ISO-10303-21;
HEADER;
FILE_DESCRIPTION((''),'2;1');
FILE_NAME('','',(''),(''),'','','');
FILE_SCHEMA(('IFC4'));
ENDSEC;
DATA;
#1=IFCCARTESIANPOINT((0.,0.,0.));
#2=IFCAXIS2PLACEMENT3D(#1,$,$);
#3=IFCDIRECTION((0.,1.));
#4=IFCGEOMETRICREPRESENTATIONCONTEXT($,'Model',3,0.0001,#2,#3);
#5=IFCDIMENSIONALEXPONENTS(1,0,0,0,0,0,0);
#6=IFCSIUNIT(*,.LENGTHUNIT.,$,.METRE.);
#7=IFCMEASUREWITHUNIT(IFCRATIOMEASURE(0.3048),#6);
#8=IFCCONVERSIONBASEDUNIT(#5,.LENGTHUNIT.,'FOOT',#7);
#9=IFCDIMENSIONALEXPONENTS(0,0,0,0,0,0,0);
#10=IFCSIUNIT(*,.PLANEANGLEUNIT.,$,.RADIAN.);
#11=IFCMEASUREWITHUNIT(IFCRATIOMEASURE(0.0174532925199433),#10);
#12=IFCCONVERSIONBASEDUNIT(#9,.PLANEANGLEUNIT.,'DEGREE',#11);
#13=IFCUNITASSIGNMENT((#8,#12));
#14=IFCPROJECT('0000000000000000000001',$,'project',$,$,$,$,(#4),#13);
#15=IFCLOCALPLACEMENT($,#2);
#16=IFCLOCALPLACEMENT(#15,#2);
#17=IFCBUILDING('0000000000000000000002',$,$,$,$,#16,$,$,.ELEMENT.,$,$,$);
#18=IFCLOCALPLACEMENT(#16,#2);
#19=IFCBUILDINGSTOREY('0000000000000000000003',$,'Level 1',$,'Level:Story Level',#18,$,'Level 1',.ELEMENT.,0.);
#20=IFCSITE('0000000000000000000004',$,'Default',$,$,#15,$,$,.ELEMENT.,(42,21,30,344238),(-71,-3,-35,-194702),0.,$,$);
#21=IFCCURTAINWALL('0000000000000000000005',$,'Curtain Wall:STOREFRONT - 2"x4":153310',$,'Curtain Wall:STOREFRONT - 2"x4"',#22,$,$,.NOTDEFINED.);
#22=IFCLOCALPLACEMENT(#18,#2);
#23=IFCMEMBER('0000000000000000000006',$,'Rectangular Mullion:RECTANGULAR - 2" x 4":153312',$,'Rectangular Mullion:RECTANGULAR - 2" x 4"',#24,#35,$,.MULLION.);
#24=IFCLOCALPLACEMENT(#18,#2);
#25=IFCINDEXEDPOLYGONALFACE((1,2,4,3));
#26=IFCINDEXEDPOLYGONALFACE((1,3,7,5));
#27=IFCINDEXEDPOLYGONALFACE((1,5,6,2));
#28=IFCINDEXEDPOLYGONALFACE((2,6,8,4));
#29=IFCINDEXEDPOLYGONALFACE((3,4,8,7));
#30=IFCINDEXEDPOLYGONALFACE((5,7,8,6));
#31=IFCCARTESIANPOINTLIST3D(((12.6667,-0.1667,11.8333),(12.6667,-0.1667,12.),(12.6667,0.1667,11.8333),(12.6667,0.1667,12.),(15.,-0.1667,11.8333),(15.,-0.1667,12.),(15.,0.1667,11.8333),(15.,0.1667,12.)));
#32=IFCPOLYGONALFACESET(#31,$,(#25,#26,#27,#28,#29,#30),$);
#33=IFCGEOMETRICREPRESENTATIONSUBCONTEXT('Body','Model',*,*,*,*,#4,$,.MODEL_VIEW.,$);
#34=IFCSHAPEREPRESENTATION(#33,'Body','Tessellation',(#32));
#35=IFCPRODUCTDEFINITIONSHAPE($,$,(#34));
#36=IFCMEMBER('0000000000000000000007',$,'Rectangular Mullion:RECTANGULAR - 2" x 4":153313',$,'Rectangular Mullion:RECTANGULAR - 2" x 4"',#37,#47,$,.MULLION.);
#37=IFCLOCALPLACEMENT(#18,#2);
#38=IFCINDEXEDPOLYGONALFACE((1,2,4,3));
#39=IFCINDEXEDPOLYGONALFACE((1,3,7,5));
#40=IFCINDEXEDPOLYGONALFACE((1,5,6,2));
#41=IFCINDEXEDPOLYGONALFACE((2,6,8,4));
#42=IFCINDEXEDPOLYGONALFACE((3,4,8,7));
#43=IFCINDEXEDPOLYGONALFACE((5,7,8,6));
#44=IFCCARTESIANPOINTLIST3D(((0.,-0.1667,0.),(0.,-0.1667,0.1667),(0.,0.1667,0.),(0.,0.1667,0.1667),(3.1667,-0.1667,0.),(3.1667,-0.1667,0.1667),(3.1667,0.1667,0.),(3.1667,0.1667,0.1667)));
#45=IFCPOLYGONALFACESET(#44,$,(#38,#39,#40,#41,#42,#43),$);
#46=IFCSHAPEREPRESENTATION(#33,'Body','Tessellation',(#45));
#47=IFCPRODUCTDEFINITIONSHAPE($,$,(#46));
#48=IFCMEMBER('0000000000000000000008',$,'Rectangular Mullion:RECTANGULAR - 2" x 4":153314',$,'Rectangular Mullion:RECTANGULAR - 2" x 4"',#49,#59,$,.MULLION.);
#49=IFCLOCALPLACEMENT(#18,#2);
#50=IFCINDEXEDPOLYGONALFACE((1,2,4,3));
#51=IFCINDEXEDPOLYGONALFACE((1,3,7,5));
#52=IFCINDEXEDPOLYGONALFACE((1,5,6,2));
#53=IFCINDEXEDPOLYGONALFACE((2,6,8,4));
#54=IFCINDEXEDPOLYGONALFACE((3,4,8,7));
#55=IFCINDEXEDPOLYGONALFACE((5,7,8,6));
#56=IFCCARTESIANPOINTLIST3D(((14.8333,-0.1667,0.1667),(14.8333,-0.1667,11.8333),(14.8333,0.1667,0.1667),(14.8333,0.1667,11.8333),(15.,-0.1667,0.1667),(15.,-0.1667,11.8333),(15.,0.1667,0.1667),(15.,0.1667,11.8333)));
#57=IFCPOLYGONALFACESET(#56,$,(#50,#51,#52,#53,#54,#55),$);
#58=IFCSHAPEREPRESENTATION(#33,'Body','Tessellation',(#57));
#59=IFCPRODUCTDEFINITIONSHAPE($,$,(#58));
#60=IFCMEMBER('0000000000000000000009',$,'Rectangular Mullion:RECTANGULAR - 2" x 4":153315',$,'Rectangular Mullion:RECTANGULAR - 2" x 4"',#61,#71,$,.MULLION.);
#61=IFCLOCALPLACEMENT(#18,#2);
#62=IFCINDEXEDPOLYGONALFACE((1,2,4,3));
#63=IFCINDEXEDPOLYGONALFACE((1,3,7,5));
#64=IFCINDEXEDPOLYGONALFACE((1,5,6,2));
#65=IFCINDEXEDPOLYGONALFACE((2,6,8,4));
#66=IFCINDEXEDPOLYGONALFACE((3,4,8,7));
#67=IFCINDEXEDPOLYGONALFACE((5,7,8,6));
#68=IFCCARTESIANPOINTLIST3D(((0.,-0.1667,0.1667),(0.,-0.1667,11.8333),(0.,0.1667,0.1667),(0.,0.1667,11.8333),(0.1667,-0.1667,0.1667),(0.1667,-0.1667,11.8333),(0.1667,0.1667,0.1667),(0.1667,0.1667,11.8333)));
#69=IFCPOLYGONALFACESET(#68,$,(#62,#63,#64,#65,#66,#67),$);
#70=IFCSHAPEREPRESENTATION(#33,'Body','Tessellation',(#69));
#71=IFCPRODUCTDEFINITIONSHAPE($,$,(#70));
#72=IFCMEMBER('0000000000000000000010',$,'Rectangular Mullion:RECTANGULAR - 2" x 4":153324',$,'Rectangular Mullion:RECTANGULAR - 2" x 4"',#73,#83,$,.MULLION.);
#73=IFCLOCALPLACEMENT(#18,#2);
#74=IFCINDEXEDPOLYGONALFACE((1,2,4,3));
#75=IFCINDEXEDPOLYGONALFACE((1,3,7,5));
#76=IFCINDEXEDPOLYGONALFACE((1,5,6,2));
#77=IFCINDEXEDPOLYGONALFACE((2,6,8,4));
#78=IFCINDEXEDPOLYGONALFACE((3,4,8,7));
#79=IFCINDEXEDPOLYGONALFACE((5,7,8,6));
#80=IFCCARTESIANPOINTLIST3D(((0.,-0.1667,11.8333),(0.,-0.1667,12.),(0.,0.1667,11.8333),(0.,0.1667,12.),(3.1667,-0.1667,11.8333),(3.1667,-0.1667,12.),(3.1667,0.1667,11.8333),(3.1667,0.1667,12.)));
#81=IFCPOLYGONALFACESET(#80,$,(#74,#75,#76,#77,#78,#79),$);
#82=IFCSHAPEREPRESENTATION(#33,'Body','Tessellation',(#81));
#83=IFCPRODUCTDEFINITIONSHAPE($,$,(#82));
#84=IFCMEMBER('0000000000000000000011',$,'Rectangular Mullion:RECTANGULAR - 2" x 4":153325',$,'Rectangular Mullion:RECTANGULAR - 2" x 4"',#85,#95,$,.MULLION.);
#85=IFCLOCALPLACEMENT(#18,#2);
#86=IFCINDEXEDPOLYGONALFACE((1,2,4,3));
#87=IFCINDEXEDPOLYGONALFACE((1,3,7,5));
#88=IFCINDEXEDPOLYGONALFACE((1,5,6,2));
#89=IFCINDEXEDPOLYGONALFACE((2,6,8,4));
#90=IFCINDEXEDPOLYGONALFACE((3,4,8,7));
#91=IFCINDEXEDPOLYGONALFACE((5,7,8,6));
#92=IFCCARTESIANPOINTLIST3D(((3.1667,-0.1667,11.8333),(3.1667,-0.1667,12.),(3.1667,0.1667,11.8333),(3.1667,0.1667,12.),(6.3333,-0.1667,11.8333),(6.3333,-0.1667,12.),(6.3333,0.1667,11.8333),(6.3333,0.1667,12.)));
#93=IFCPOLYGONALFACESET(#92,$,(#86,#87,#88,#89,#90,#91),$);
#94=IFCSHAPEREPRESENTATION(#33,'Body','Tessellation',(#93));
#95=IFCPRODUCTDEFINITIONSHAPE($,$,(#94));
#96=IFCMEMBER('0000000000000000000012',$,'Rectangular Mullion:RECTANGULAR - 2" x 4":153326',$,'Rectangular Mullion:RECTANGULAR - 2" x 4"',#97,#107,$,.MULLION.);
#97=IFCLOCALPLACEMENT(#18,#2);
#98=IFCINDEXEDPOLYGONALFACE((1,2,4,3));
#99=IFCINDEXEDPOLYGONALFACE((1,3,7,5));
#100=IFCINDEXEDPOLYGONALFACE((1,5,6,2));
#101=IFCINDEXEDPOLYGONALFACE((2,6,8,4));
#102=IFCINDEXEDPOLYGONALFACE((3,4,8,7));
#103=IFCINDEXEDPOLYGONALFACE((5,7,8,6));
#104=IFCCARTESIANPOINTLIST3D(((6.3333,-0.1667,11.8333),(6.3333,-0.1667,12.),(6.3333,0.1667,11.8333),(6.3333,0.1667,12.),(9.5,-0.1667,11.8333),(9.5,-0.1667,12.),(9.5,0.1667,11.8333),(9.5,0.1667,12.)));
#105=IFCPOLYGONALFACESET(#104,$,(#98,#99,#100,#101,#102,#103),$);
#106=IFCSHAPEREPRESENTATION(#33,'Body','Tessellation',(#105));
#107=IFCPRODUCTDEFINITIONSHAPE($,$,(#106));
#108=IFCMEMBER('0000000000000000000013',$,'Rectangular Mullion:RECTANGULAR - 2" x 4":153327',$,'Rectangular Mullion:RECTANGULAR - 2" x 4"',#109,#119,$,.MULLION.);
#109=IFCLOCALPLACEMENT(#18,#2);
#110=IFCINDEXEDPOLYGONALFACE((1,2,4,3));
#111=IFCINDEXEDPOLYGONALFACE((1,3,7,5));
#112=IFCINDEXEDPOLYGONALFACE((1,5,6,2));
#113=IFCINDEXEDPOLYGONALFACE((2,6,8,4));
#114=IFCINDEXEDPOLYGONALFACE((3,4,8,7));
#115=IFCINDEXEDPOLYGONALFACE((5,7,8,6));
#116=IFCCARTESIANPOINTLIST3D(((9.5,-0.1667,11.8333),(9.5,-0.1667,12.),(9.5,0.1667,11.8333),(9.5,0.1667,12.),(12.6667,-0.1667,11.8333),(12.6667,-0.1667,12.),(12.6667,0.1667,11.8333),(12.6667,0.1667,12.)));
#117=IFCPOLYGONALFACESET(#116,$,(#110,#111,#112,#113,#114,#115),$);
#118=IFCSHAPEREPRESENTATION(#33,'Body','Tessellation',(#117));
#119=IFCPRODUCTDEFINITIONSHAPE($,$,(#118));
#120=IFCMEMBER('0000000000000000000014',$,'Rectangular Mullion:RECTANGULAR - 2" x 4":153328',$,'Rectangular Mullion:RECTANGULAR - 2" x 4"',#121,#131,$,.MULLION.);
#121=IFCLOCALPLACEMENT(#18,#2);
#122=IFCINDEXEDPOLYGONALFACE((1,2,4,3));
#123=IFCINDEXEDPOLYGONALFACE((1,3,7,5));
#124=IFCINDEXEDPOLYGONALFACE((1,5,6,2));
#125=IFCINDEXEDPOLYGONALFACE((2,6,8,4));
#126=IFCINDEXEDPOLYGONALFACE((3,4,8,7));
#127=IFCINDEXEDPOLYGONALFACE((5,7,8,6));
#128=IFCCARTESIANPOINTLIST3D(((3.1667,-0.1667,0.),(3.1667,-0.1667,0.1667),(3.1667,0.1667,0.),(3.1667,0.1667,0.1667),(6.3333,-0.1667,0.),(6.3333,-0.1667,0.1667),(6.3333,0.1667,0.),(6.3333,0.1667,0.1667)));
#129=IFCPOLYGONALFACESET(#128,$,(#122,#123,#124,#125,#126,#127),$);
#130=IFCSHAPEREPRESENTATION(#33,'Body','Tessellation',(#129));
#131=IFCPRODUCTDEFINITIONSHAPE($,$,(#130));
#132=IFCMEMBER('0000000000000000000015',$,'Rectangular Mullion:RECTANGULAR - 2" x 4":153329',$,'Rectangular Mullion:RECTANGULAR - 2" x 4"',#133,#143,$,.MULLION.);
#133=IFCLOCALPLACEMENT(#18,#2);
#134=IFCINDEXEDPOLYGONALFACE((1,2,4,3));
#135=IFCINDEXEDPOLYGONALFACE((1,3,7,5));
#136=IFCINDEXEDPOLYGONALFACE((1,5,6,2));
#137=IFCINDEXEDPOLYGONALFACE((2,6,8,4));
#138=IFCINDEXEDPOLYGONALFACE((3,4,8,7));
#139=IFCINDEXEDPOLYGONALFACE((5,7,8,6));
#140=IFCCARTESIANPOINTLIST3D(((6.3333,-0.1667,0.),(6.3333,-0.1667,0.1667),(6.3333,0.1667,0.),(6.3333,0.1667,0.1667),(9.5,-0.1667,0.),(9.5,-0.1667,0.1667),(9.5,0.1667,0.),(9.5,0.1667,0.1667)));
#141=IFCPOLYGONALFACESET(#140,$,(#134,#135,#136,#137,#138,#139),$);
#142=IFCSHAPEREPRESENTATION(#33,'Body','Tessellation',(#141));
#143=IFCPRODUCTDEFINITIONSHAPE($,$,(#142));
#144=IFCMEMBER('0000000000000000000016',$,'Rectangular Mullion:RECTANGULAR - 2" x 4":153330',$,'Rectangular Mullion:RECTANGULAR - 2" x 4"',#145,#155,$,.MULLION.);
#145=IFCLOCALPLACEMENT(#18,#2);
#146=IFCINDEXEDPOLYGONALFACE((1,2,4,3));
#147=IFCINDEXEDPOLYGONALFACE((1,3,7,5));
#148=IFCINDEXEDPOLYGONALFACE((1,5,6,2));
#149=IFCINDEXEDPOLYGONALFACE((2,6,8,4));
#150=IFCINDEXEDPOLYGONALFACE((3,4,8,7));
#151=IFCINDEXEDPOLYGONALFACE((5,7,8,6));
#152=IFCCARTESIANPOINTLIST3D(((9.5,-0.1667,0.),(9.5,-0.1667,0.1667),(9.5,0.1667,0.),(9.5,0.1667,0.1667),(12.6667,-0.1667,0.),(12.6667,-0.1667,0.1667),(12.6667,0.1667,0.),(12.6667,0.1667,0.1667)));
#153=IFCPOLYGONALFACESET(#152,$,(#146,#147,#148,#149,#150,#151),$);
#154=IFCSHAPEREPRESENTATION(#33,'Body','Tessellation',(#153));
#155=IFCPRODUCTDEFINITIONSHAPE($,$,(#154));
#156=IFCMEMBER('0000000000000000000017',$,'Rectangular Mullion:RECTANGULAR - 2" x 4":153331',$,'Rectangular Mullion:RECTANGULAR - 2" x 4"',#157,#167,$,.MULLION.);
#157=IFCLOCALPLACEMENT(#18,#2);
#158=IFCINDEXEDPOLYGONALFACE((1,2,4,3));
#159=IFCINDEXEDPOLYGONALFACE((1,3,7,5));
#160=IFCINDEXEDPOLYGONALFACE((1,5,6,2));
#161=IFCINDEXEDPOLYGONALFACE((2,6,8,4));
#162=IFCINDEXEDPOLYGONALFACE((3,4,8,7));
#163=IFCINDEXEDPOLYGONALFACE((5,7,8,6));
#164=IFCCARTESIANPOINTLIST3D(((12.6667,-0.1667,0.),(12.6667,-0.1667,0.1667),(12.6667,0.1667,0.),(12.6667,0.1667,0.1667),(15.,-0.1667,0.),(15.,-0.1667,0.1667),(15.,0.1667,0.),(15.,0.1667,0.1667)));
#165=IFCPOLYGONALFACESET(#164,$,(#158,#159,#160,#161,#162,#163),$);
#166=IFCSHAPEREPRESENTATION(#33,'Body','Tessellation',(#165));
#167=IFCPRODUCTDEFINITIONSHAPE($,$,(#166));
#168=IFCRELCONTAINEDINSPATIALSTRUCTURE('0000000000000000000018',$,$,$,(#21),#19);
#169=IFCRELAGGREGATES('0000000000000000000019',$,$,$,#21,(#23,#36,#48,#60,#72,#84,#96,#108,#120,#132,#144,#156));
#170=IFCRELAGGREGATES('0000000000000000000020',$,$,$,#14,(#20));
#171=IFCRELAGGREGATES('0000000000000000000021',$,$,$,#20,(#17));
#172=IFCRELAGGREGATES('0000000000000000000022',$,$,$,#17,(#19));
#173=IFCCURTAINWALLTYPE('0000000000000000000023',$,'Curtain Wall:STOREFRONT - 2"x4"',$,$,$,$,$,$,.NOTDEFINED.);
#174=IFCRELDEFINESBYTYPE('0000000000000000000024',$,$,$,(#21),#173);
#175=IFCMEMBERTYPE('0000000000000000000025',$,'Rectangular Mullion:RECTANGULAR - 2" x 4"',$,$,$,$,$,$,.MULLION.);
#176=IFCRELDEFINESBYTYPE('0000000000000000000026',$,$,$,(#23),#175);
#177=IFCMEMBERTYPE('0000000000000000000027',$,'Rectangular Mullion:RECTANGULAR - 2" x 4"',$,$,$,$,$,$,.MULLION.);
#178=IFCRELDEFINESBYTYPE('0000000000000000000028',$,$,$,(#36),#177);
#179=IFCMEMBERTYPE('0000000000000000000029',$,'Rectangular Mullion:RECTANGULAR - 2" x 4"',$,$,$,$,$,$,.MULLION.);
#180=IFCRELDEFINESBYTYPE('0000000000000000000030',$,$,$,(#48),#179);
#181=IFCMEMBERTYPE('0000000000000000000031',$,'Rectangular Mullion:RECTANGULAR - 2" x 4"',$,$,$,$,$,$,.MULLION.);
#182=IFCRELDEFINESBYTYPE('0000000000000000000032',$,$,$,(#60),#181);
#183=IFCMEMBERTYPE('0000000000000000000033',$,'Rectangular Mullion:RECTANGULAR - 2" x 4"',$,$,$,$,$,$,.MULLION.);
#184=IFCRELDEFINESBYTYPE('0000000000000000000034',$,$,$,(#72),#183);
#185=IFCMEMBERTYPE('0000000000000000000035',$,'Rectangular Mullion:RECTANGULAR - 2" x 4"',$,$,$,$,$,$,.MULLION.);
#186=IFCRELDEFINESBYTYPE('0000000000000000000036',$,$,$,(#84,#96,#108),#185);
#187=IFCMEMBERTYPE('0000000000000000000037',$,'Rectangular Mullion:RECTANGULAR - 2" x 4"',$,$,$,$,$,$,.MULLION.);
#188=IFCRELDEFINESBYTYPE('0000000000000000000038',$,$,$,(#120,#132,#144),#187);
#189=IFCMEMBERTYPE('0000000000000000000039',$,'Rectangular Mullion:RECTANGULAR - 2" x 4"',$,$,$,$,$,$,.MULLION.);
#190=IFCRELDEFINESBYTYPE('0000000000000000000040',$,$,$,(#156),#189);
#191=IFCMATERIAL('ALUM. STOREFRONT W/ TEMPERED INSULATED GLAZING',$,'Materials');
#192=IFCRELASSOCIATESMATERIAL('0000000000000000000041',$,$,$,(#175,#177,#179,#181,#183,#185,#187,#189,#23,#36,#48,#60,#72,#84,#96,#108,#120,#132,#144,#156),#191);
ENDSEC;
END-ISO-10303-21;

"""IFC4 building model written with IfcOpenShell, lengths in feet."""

from ifc_helpers import new_model, entity, si_unit, converted_unit, direction, frame, origin, origin_2d_with_axis, place, context, subcontext, project, spatial, rectangle, extrude, source, transform, mapped, material, material_profile, profile_set, profile_usage, type_object, type_shapes, element, aggregate, save


model = new_model("IFC4")

# Units and contexts
model_context = context("Model", 3, precision=0.0001, world=origin(), true_north=direction((0.0, 1.0)))
body_context = subcontext(model_context, "Body", "Model", "MODEL_VIEW")
ifc_project = project(units=[converted_unit("LENGTHUNIT", "FOOT", entity("IfcRatioMeasure", 0.3048), si_unit("LENGTHUNIT", "METRE"), dimensions=[1, 0, 0, 0, 0, 0, 0]), converted_unit("PLANEANGLEUNIT", "DEGREE", entity("IfcRatioMeasure", 0.0174532925199433), si_unit("PLANEANGLEUNIT", "RADIAN"), dimensions=[0, 0, 0, 0, 0, 0, 0])], contexts=[model_context])

# Site, building, storey
site_placement = place(None, origin())
site = spatial("IfcSite", under=ifc_project, at=site_placement, Name="Default", CompositionType="ELEMENT", RefLatitude=(42, 21, 30, 344238), RefLongitude=(-71, -3, -35, -194702), RefElevation=0.0)
building_placement = place(site_placement, origin())
building = spatial("IfcBuilding", under=site, at=building_placement, CompositionType="ELEMENT")
storey_placement = place(building_placement, origin())
storey = spatial("IfcBuildingStorey", under=building, at=storey_placement, Name="Level 1", ObjectType="Level:Story Level", LongName="Level 1", CompositionType="ELEMENT", Elevation=0.0)

# Curtain wall, members
curtain_wall_type = type_object("IfcCurtainWallType", Name="Curtain Wall:STOREFRONT - 2\"x4\"", PredefinedType="NOTDEFINED")
curtain_wall_placement = place(storey_placement, origin())
curtain_wall = element("IfcCurtainWall", 1, at=curtain_wall_placement, inside=storey, type_object=curtain_wall_type, Name="Curtain Wall:STOREFRONT - 2\"x4\":153310", ObjectType="Curtain Wall:STOREFRONT - 2\"x4\"", PredefinedType="NOTDEFINED")
ifc_material_1 = material(Name="ALUM. STOREFRONT W/ TEMPERED INSULATED GLAZING", Category="Materials")
ifc_material_profile = material_profile(ifc_material_1, rectangle(XDim=0.3333, YDim=0.1667, at=origin_2d_with_axis()), Name="RECTANGULAR - 2\" x 4\"")
ifc_profile_set = profile_set([ifc_material_profile], Name="RECTANGULAR - 2\" x 4\"")
ifc_profile_usage_1 = profile_usage(ifc_profile_set)
member_type_1 = type_object("IfcMemberType", Name="Rectangular Mullion:RECTANGULAR - 2\" x 4\"", PredefinedType="MULLION", material=ifc_profile_set)
shared_shape_1 = source(origin(), body_context, "Body", "SweptSolid", [
    extrude(rectangle(XDim=0.3333, YDim=0.1667, at=origin_2d_with_axis()), frame((-0.0833, 0.0, -2.3333), z_axis=(0.0, 0.0, 1.0), x_axis=(0.0, -1.0, 0.0)), (0.0, 0.0, 1.0), 2.3333),
])
type_shapes(member_type_1, [shared_shape_1])
member_1_placement = place(storey_placement, frame((15.0, 0.0, 12.0), z_axis=(1.0, 0.0, 0.0), x_axis=(0.0, 0.0, 1.0)))
member_1 = element("IfcMember", 2, at=member_1_placement, type_object=member_type_1, material=ifc_profile_usage_1, Name="Rectangular Mullion:RECTANGULAR - 2\" x 4\":153312", ObjectType="Rectangular Mullion:RECTANGULAR - 2\" x 4\"", PredefinedType="MULLION", context=body_context, shape_type="MappedRepresentation", body=[
    mapped(shared_shape_1, transform((0.0, 0.0, 0.0), scale=1.0)),
])
ifc_profile_usage_2 = profile_usage(ifc_profile_set)
member_type_2 = type_object("IfcMemberType", Name="Rectangular Mullion:RECTANGULAR - 2\" x 4\"", PredefinedType="MULLION", material=ifc_profile_set)
shared_shape_2 = source(origin(), body_context, "Body", "SweptSolid", [
    extrude(rectangle(XDim=0.3333, YDim=0.1667, at=origin_2d_with_axis()), frame((-0.0833, 0.0, -3.1667), z_axis=(0.0, 0.0, 1.0), x_axis=(0.0, -1.0, 0.0)), (0.0, 0.0, 1.0), 3.1667),
])
type_shapes(member_type_2, [shared_shape_2])
member_2_placement = place(storey_placement, frame((0.0, 0.0, 0.0), z_axis=(-1.0, 0.0, 0.0), x_axis=(0.0, 0.0, -1.0)))
member_2 = element("IfcMember", 3, at=member_2_placement, type_object=member_type_2, material=ifc_profile_usage_2, Name="Rectangular Mullion:RECTANGULAR - 2\" x 4\":153313", ObjectType="Rectangular Mullion:RECTANGULAR - 2\" x 4\"", PredefinedType="MULLION", context=body_context, shape_type="MappedRepresentation", body=[
    mapped(shared_shape_2, transform((0.0, 0.0, 0.0), scale=1.0)),
])
ifc_profile_usage_3 = profile_usage(ifc_profile_set)
member_type_3 = type_object("IfcMemberType", Name="Rectangular Mullion:RECTANGULAR - 2\" x 4\"", PredefinedType="MULLION", material=ifc_profile_set)
shared_shape_3 = source(origin(), body_context, "Body", "SweptSolid", [
    extrude(rectangle(XDim=0.3333, YDim=0.1667, at=origin_2d_with_axis()), frame((-0.0833, 0.0, -11.6667), z_axis=(0.0, 0.0, 1.0), x_axis=(0.0, -1.0, 0.0)), (0.0, 0.0, 1.0), 11.6667),
])
type_shapes(member_type_3, [shared_shape_3])
member_3_placement = place(storey_placement, frame((15.0, 0.0, 0.1667), z_axis=(0.0, 0.0, -1.0), x_axis=(1.0, 0.0, 0.0)))
member_3 = element("IfcMember", 4, at=member_3_placement, type_object=member_type_3, material=ifc_profile_usage_3, Name="Rectangular Mullion:RECTANGULAR - 2\" x 4\":153314", ObjectType="Rectangular Mullion:RECTANGULAR - 2\" x 4\"", PredefinedType="MULLION", context=body_context, shape_type="MappedRepresentation", body=[
    mapped(shared_shape_3, transform((0.0, 0.0, 0.0), scale=1.0)),
])
ifc_profile_usage_4 = profile_usage(ifc_profile_set)
member_type_4 = type_object("IfcMemberType", Name="Rectangular Mullion:RECTANGULAR - 2\" x 4\"", PredefinedType="MULLION", material=ifc_profile_set)
shared_shape_4 = source(origin(), body_context, "Body", "SweptSolid", [
    extrude(rectangle(XDim=0.3333, YDim=0.1667, at=origin_2d_with_axis()), frame((-0.0833, 0.0, -11.6667), z_axis=(0.0, 0.0, 1.0), x_axis=(0.0, -1.0, 0.0)), (0.0, 0.0, 1.0), 11.6667),
])
type_shapes(member_type_4, [shared_shape_4])
member_4_placement = place(storey_placement, frame((0.0, 0.0, 11.8333), z_axis=(0.0, 0.0, 1.0), x_axis=(-1.0, 0.0, 0.0)))
member_4 = element("IfcMember", 5, at=member_4_placement, type_object=member_type_4, material=ifc_profile_usage_4, Name="Rectangular Mullion:RECTANGULAR - 2\" x 4\":153315", ObjectType="Rectangular Mullion:RECTANGULAR - 2\" x 4\"", PredefinedType="MULLION", context=body_context, shape_type="MappedRepresentation", body=[
    mapped(shared_shape_4, transform((0.0, 0.0, 0.0), scale=1.0)),
])
ifc_profile_usage_5 = profile_usage(ifc_profile_set)
member_type_5 = type_object("IfcMemberType", Name="Rectangular Mullion:RECTANGULAR - 2\" x 4\"", PredefinedType="MULLION", material=ifc_profile_set)
shared_shape_5 = source(origin(), body_context, "Body", "SweptSolid", [
    extrude(rectangle(XDim=0.3333, YDim=0.1667, at=origin_2d_with_axis()), frame((-0.0833, 0.0, -3.1667), z_axis=(0.0, 0.0, 1.0), x_axis=(0.0, -1.0, 0.0)), (0.0, 0.0, 1.0), 3.1667),
])
type_shapes(member_type_5, [shared_shape_5])
member_5_placement = place(storey_placement, frame((3.1667, 0.0, 12.0), z_axis=(1.0, 0.0, 0.0), x_axis=(0.0, 0.0, 1.0)))
member_5 = element("IfcMember", 6, at=member_5_placement, type_object=member_type_5, material=ifc_profile_usage_5, Name="Rectangular Mullion:RECTANGULAR - 2\" x 4\":153324", ObjectType="Rectangular Mullion:RECTANGULAR - 2\" x 4\"", PredefinedType="MULLION", context=body_context, shape_type="MappedRepresentation", body=[
    mapped(shared_shape_5, transform((0.0, 0.0, 0.0), scale=1.0)),
])
ifc_profile_usage_6 = profile_usage(ifc_profile_set)
member_type_6 = type_object("IfcMemberType", Name="Rectangular Mullion:RECTANGULAR - 2\" x 4\"", PredefinedType="MULLION", material=ifc_profile_set)
shared_shape_6 = source(origin(), body_context, "Body", "SweptSolid", [
    extrude(rectangle(XDim=0.3333, YDim=0.1667, at=origin_2d_with_axis()), frame((-0.0833, 0.0, -3.1667), z_axis=(0.0, 0.0, 1.0), x_axis=(0.0, -1.0, 0.0)), (0.0, 0.0, 1.0), 3.1667),
])
type_shapes(member_type_6, [shared_shape_6])
member_6_placement = place(storey_placement, frame((6.3333, 0.0, 12.0), z_axis=(1.0, 0.0, 0.0), x_axis=(0.0, 0.0, 1.0)))
member_6 = element("IfcMember", 7, at=member_6_placement, type_object=member_type_6, material=ifc_profile_usage_6, Name="Rectangular Mullion:RECTANGULAR - 2\" x 4\":153325", ObjectType="Rectangular Mullion:RECTANGULAR - 2\" x 4\"", PredefinedType="MULLION", context=body_context, shape_type="MappedRepresentation", body=[
    mapped(shared_shape_6, transform((0.0, 0.0, 0.0), scale=1.0)),
])
ifc_profile_usage_7 = profile_usage(ifc_profile_set)
member_7_placement = place(storey_placement, frame((9.5, 0.0, 12.0), z_axis=(1.0, 0.0, 0.0), x_axis=(0.0, 0.0, 1.0)))
member_7 = element("IfcMember", 8, at=member_7_placement, type_object=member_type_6, material=ifc_profile_usage_7, Name="Rectangular Mullion:RECTANGULAR - 2\" x 4\":153326", ObjectType="Rectangular Mullion:RECTANGULAR - 2\" x 4\"", PredefinedType="MULLION", context=body_context, shape_type="MappedRepresentation", body=[
    mapped(shared_shape_6, transform((0.0, 0.0, 0.0), scale=1.0)),
])
ifc_profile_usage_8 = profile_usage(ifc_profile_set)
member_8_placement = place(storey_placement, frame((12.6667, 0.0, 12.0), z_axis=(1.0, 0.0, 0.0), x_axis=(0.0, 0.0, 1.0)))
member_8 = element("IfcMember", 9, at=member_8_placement, type_object=member_type_6, material=ifc_profile_usage_8, Name="Rectangular Mullion:RECTANGULAR - 2\" x 4\":153327", ObjectType="Rectangular Mullion:RECTANGULAR - 2\" x 4\"", PredefinedType="MULLION", context=body_context, shape_type="MappedRepresentation", body=[
    mapped(shared_shape_6, transform((0.0, 0.0, 0.0), scale=1.0)),
])
ifc_profile_usage_9 = profile_usage(ifc_profile_set)
member_type_7 = type_object("IfcMemberType", Name="Rectangular Mullion:RECTANGULAR - 2\" x 4\"", PredefinedType="MULLION", material=ifc_profile_set)
shared_shape_7 = source(origin(), body_context, "Body", "SweptSolid", [
    extrude(rectangle(XDim=0.3333, YDim=0.1667, at=origin_2d_with_axis()), frame((-0.0833, 0.0, -3.1667), z_axis=(0.0, 0.0, 1.0), x_axis=(0.0, -1.0, 0.0)), (0.0, 0.0, 1.0), 3.1667),
])
type_shapes(member_type_7, [shared_shape_7])
member_9_placement = place(storey_placement, frame((3.1667, 0.0, 0.0), z_axis=(-1.0, 0.0, 0.0), x_axis=(0.0, 0.0, -1.0)))
member_9 = element("IfcMember", 10, at=member_9_placement, type_object=member_type_7, material=ifc_profile_usage_9, Name="Rectangular Mullion:RECTANGULAR - 2\" x 4\":153328", ObjectType="Rectangular Mullion:RECTANGULAR - 2\" x 4\"", PredefinedType="MULLION", context=body_context, shape_type="MappedRepresentation", body=[
    mapped(shared_shape_7, transform((0.0, 0.0, 0.0), scale=1.0)),
])
ifc_profile_usage_10 = profile_usage(ifc_profile_set)
member_10_placement = place(storey_placement, frame((6.3333, 0.0, 0.0), z_axis=(-1.0, 0.0, 0.0), x_axis=(0.0, 0.0, -1.0)))
member_10 = element("IfcMember", 11, at=member_10_placement, type_object=member_type_7, material=ifc_profile_usage_10, Name="Rectangular Mullion:RECTANGULAR - 2\" x 4\":153329", ObjectType="Rectangular Mullion:RECTANGULAR - 2\" x 4\"", PredefinedType="MULLION", context=body_context, shape_type="MappedRepresentation", body=[
    mapped(shared_shape_7, transform((0.0, 0.0, 0.0), scale=1.0)),
])
ifc_profile_usage_11 = profile_usage(ifc_profile_set)
member_11_placement = place(storey_placement, frame((9.5, 0.0, 0.0), z_axis=(-1.0, 0.0, 0.0), x_axis=(0.0, 0.0, -1.0)))
member_11 = element("IfcMember", 12, at=member_11_placement, type_object=member_type_7, material=ifc_profile_usage_11, Name="Rectangular Mullion:RECTANGULAR - 2\" x 4\":153330", ObjectType="Rectangular Mullion:RECTANGULAR - 2\" x 4\"", PredefinedType="MULLION", context=body_context, shape_type="MappedRepresentation", body=[
    mapped(shared_shape_7, transform((0.0, 0.0, 0.0), scale=1.0)),
])
ifc_profile_usage_12 = profile_usage(ifc_profile_set)
member_type_8 = type_object("IfcMemberType", Name="Rectangular Mullion:RECTANGULAR - 2\" x 4\"", PredefinedType="MULLION", material=ifc_profile_set)
shared_shape_8 = source(origin(), body_context, "Body", "SweptSolid", [
    extrude(rectangle(XDim=0.3333, YDim=0.1667, at=origin_2d_with_axis()), frame((-0.0833, 0.0, -2.3333), z_axis=(0.0, 0.0, 1.0), x_axis=(0.0, -1.0, 0.0)), (0.0, 0.0, 1.0), 2.3333),
])
type_shapes(member_type_8, [shared_shape_8])
member_12_placement = place(storey_placement, frame((12.6667, 0.0, 0.0), z_axis=(-1.0, 0.0, 0.0), x_axis=(0.0, 0.0, -1.0)))
member_12 = element("IfcMember", 13, at=member_12_placement, type_object=member_type_8, material=ifc_profile_usage_12, Name="Rectangular Mullion:RECTANGULAR - 2\" x 4\":153331", ObjectType="Rectangular Mullion:RECTANGULAR - 2\" x 4\"", PredefinedType="MULLION", context=body_context, shape_type="MappedRepresentation", body=[
    mapped(shared_shape_8, transform((0.0, 0.0, 0.0), scale=1.0)),
])
aggregate(curtain_wall, [member_1, member_2, member_3, member_4, member_5, member_6, member_7, member_8, member_9, member_10, member_11, member_12])

save(model, "model.ifc")
